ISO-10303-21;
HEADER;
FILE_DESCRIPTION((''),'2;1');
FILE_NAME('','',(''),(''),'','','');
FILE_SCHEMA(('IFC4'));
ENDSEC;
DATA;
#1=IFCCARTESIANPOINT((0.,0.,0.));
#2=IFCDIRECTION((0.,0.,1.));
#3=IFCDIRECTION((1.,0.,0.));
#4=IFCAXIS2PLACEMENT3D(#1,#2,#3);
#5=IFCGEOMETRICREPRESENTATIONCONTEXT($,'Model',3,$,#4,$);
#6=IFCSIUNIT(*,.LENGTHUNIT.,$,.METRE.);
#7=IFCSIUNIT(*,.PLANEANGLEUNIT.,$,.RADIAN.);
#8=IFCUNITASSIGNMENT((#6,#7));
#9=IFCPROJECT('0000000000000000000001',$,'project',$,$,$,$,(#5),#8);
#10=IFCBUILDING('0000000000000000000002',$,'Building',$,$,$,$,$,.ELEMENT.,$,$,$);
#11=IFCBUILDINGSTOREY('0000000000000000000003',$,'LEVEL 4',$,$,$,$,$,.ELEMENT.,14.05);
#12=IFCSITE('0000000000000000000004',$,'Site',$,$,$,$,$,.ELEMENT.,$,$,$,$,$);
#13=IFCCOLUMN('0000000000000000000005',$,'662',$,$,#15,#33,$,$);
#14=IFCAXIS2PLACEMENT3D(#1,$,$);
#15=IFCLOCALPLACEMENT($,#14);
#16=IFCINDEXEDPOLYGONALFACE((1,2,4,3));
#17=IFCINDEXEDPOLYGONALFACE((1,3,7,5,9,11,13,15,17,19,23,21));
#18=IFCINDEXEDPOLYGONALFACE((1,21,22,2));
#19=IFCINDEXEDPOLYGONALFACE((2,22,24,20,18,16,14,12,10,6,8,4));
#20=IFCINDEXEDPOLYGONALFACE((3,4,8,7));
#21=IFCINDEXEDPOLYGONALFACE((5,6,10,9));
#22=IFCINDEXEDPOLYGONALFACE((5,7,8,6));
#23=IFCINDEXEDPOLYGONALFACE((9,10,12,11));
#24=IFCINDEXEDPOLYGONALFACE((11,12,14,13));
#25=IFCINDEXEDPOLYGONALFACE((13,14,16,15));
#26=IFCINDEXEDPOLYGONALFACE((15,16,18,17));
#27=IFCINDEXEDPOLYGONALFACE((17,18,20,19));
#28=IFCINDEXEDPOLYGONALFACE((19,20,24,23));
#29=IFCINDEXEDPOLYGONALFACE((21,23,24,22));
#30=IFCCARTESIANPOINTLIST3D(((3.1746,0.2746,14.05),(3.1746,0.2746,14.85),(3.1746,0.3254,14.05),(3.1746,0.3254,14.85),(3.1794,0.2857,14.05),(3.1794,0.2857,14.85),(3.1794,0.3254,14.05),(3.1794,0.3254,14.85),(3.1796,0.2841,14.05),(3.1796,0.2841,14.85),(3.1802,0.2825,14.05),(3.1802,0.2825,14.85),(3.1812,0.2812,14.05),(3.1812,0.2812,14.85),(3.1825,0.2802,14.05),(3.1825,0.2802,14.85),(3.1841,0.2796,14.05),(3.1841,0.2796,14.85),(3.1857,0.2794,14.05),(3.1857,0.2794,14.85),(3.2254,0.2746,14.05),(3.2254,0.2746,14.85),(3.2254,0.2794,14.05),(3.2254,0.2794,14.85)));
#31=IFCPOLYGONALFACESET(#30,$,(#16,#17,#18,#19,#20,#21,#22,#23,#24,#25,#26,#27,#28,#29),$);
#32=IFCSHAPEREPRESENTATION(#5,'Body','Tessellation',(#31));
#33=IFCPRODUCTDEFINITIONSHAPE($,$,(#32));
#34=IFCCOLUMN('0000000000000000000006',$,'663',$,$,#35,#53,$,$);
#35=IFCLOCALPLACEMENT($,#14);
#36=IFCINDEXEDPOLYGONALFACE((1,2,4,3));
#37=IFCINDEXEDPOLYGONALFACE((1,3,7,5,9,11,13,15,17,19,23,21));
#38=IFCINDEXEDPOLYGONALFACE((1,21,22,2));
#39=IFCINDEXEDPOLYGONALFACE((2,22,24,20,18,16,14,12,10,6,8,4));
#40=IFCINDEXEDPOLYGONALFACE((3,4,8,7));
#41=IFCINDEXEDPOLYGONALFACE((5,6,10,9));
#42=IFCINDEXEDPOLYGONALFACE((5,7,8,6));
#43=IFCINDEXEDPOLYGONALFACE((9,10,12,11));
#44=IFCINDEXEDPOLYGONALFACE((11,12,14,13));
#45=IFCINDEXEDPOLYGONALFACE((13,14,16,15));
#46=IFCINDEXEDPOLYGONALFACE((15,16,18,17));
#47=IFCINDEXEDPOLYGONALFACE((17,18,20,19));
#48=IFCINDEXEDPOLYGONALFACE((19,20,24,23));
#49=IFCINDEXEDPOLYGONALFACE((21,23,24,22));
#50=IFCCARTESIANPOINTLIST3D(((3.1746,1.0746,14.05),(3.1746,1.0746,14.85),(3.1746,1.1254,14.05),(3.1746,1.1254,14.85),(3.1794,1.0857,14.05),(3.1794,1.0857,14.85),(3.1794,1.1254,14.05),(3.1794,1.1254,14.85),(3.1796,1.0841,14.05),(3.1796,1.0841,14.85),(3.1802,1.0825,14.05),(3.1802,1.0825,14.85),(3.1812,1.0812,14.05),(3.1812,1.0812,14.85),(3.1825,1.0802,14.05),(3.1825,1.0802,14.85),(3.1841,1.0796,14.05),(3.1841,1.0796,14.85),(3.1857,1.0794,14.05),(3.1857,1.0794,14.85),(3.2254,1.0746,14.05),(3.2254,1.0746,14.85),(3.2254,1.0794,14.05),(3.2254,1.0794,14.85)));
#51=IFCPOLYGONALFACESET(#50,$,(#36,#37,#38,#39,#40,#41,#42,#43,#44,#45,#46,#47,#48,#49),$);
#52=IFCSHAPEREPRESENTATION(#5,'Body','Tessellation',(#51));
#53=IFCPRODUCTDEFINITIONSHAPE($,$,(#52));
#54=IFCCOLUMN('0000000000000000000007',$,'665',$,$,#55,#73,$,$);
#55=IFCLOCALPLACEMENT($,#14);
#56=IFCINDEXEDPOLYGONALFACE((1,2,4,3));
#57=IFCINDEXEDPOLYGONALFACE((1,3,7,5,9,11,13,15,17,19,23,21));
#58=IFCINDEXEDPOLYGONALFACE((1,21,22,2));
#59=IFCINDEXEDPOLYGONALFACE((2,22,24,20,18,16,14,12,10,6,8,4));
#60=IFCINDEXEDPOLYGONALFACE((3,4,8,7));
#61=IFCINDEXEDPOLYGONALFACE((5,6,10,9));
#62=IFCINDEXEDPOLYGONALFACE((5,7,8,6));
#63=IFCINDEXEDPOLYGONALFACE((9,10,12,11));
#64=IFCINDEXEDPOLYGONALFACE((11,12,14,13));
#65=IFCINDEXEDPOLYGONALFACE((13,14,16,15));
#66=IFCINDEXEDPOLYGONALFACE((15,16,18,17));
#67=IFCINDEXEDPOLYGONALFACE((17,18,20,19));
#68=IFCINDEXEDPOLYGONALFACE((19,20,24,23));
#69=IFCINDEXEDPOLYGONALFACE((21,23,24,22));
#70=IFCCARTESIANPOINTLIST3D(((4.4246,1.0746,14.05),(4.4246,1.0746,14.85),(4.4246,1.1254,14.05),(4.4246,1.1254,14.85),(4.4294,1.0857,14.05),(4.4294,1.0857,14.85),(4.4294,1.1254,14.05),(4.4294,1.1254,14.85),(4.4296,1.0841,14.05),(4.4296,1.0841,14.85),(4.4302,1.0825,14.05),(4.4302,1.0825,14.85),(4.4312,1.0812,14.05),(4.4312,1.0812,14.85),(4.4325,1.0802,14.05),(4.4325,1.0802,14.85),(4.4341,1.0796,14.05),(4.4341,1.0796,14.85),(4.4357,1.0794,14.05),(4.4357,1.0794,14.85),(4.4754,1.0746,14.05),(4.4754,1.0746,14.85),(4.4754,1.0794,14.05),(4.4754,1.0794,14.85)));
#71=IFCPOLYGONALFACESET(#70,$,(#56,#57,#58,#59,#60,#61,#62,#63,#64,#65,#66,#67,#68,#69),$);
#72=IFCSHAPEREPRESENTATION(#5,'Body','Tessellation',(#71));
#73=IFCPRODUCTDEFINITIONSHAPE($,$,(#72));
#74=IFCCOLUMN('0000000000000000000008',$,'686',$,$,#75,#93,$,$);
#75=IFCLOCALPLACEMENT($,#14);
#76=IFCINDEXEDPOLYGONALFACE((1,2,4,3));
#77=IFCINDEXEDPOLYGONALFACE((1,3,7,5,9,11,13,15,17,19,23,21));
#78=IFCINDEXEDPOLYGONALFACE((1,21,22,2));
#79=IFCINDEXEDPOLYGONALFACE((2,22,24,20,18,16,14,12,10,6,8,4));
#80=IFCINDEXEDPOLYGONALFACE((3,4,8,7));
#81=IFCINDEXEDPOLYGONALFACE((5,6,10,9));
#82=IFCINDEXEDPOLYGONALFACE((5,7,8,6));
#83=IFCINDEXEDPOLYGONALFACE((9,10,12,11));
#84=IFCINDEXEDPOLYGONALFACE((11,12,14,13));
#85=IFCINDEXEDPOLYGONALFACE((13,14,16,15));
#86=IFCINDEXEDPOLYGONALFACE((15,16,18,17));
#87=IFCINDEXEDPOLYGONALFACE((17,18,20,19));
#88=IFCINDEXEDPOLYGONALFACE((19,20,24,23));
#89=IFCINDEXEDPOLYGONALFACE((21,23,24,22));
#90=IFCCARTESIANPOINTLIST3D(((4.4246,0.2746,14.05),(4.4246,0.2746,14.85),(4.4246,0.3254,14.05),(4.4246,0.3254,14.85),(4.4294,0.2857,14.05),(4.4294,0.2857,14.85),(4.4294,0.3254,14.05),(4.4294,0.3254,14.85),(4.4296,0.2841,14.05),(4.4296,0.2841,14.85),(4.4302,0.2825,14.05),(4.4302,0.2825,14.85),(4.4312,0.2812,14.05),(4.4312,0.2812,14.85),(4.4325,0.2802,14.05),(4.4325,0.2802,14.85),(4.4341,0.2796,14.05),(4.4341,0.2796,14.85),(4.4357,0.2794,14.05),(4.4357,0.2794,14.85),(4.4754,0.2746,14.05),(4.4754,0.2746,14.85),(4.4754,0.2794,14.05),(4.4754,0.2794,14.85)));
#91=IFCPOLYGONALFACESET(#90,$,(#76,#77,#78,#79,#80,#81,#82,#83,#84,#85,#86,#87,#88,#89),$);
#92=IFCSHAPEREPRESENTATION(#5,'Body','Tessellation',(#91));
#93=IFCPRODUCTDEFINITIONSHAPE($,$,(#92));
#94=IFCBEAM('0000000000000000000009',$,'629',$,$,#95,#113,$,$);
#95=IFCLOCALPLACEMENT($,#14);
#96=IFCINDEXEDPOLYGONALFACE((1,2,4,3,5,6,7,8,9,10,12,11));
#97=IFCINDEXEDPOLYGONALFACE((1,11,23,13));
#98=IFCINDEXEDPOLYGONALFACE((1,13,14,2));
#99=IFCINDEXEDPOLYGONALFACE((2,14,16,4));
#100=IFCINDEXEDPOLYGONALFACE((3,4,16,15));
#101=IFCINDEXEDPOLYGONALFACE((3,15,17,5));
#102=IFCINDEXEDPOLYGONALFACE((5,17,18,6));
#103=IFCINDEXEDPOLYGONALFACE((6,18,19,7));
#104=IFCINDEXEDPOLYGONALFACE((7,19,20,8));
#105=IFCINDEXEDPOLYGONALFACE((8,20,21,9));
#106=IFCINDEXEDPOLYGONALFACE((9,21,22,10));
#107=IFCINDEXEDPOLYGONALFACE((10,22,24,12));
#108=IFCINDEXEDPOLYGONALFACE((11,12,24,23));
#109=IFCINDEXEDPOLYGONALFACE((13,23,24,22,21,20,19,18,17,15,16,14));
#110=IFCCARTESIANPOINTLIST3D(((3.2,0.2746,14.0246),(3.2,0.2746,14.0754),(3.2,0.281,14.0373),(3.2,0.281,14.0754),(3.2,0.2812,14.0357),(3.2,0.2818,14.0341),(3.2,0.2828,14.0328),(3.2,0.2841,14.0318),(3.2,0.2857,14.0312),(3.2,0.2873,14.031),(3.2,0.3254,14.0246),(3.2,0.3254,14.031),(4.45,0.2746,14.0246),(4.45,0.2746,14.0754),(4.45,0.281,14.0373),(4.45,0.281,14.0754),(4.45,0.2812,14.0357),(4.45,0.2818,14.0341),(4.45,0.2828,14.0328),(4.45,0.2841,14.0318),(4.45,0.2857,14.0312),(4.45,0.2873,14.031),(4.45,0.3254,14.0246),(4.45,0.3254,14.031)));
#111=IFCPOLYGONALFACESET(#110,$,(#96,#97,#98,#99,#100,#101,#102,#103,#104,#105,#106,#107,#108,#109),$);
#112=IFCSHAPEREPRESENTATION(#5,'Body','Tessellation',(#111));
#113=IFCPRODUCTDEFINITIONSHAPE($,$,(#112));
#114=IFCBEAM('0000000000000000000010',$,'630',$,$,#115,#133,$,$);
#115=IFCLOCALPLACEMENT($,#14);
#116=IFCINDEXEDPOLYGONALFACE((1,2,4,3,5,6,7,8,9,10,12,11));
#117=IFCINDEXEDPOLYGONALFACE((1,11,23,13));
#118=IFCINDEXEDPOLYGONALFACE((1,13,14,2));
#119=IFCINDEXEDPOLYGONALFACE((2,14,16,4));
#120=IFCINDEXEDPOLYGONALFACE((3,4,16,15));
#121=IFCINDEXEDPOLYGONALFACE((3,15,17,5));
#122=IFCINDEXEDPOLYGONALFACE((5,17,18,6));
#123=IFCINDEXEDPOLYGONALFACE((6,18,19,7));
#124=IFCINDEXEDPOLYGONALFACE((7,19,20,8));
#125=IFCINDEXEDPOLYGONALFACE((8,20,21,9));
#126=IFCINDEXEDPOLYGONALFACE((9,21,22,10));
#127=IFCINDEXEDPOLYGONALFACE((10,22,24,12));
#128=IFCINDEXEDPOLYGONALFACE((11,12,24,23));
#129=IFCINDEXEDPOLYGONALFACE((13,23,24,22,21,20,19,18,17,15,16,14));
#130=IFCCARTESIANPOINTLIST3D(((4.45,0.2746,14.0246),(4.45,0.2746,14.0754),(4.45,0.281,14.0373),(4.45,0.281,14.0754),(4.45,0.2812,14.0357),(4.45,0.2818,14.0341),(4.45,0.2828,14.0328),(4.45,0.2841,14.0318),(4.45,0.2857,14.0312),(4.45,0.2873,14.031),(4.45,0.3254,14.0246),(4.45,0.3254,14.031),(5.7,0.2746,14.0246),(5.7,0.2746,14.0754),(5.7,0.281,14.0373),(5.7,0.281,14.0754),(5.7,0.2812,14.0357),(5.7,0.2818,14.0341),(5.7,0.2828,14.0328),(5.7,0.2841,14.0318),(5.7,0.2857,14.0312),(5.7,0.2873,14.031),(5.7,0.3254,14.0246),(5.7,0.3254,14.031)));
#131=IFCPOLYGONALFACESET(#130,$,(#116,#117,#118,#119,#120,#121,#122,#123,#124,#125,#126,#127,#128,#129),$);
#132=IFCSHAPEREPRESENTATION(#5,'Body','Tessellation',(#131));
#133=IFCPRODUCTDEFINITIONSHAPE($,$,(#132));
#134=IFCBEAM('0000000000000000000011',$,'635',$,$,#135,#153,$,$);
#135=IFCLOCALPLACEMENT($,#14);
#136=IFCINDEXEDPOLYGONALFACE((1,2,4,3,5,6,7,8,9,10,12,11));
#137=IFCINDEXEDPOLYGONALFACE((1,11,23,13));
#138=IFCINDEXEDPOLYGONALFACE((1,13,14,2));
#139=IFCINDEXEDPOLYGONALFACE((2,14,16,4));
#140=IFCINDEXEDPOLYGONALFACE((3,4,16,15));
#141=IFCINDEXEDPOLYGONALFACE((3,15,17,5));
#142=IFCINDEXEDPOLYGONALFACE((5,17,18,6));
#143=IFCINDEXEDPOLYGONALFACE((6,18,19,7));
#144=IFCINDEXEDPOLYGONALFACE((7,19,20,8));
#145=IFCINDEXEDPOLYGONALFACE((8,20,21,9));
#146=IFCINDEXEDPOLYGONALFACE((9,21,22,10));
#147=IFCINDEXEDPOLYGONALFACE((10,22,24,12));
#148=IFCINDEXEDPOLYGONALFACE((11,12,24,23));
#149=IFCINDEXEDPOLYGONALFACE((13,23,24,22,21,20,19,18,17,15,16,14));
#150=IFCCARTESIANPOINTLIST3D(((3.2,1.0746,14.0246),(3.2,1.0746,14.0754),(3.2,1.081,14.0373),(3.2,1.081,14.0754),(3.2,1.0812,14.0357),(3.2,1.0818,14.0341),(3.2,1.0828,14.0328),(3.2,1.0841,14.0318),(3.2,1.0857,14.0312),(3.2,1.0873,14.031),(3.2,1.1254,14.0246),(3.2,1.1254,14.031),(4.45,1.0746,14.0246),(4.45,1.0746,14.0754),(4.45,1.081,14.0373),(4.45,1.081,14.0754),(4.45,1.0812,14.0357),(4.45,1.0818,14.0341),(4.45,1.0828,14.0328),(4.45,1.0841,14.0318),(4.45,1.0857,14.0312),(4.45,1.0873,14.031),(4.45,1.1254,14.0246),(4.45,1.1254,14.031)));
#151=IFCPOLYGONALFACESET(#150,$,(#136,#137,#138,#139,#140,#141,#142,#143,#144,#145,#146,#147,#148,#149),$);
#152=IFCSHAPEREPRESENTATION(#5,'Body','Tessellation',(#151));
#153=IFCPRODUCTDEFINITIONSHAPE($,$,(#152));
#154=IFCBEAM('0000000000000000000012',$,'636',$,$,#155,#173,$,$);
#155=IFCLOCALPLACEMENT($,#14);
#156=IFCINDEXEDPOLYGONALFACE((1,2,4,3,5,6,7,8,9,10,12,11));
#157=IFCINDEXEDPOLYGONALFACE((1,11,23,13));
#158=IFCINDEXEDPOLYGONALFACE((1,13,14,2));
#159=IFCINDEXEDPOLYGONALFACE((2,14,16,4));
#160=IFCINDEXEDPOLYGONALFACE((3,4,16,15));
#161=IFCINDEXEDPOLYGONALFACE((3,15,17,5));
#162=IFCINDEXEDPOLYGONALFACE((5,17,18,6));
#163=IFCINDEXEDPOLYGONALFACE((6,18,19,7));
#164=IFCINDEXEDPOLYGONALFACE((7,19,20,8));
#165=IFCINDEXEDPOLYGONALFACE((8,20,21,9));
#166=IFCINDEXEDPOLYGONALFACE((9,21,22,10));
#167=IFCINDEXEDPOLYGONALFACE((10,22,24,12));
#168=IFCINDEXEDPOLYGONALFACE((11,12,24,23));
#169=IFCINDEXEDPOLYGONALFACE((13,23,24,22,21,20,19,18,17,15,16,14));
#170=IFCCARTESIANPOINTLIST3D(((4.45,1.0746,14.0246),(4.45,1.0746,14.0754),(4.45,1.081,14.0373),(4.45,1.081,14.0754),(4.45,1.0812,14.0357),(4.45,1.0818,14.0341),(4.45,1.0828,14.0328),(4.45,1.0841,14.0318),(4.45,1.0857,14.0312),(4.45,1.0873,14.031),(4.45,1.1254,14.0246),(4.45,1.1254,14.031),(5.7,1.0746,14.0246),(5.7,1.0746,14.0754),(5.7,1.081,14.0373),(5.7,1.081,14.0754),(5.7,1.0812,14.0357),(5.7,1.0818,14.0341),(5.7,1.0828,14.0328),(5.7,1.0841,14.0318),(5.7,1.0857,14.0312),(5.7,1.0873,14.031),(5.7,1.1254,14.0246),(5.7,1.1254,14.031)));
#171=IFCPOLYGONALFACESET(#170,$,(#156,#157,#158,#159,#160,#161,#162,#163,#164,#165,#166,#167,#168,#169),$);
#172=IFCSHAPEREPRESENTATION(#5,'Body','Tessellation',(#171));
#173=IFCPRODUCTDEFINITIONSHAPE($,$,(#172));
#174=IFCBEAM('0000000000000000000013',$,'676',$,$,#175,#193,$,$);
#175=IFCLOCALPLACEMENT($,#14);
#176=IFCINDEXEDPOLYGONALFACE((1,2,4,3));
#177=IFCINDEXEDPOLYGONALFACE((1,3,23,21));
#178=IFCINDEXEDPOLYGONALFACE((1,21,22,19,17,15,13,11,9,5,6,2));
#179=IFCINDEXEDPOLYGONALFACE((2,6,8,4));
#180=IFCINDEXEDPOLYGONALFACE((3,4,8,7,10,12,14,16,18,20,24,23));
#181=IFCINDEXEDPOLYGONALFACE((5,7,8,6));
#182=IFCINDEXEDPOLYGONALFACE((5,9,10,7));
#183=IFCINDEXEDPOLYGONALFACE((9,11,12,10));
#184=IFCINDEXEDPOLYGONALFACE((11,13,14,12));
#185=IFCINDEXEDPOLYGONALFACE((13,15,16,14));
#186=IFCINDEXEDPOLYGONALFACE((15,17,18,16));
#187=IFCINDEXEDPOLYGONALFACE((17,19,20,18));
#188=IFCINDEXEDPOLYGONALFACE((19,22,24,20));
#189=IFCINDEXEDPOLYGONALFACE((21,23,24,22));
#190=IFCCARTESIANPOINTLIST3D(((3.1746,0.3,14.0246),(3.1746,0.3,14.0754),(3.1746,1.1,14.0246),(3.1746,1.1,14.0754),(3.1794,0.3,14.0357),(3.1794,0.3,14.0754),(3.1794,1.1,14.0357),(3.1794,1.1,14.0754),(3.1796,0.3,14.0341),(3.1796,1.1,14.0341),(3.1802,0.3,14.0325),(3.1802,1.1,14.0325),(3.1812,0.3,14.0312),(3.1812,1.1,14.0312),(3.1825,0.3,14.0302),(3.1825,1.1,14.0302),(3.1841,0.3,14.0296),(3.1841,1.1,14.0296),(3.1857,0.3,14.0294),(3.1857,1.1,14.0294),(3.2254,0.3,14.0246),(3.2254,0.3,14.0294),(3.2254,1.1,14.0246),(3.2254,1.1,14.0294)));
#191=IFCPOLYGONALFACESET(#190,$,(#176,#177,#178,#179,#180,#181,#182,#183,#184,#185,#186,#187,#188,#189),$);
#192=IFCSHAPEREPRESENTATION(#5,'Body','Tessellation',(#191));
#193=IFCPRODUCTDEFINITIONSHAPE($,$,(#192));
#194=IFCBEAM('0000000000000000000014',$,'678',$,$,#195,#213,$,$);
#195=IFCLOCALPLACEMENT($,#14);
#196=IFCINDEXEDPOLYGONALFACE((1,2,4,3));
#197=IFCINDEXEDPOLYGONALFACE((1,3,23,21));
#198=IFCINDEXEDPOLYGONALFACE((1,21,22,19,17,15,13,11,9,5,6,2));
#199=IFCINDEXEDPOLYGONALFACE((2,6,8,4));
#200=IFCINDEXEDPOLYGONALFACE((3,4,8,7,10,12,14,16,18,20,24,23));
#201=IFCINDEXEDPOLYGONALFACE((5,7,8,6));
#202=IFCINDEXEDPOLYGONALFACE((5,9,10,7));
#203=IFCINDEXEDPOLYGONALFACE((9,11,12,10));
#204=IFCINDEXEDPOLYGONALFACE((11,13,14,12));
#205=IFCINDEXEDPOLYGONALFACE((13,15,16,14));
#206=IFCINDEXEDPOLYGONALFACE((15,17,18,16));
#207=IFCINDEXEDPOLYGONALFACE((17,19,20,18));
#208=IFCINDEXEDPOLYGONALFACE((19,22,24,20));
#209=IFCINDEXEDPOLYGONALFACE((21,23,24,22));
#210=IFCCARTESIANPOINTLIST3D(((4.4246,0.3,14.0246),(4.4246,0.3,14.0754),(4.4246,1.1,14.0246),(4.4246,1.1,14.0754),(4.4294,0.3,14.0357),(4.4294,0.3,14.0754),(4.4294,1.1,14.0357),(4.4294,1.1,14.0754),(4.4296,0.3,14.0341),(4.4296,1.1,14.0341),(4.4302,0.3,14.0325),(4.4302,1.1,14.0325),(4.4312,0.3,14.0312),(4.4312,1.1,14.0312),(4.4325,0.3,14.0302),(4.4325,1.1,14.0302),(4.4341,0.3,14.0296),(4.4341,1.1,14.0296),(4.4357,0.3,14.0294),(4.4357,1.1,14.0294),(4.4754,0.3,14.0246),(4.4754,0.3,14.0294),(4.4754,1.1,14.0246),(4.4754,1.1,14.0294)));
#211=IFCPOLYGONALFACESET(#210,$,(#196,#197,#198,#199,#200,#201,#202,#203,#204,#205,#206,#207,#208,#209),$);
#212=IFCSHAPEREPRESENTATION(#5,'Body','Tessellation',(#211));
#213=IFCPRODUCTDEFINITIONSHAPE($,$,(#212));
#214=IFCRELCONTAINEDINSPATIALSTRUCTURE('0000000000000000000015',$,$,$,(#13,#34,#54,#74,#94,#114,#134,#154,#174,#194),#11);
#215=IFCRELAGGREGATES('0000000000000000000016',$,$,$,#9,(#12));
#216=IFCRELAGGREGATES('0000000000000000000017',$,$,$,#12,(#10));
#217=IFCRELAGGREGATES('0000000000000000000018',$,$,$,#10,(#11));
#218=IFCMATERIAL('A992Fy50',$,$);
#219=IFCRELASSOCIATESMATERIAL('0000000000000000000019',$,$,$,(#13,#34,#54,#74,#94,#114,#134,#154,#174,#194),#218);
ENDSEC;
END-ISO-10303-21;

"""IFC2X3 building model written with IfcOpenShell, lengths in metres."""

from ifc_helpers import new_model, si_unit, frame, origin_with_axes, origin_2d_with_axis, place, context, project, spatial, l_section, extrude, material, element, save


model = new_model("IFC2X3")

# Units and contexts
model_context = context("Model", 3, world=origin_with_axes())
ifc_project = project(units=[si_unit("LENGTHUNIT", "METRE"), si_unit("PLANEANGLEUNIT", "RADIAN")], contexts=[model_context])

# Site, building, storey
site = spatial("IfcSite", under=ifc_project, Name="Site", CompositionType="ELEMENT")
building = spatial("IfcBuilding", under=site, Name="Building", CompositionType="ELEMENT")
storey = spatial("IfcBuildingStorey", under=building, Name="LEVEL 4", CompositionType="ELEMENT", Elevation=14.05)

# Columns
ifc_material = material(Name="A992Fy50")
for number, where, z_axis, x_axis, name in (
    (1, (3.2, 0.3, 14.85), (0.0, 0.0, -1.0), (0.0, 1.0, 0.0), "662"),
    (2, (3.2, 1.1, 14.85), (0.0, 0.0, -1.0), (0.0, 1.0, 0.0), "663"),
    (3, (4.45, 1.1, 14.85), (0.0, 0.0, -1.0), (0.0, 1.0, 0.0), "665"),
    (4, (4.45, 0.3, 14.85), (0.0, 0.0, -1.0), (0.0, 1.0, 0.0), "686"),
):
    element("IfcColumn", number, at=place(None, frame(where, z_axis=z_axis, x_axis=x_axis)), inside=storey, material=ifc_material, Name=name, context=model_context, shape_type="SweptSolid", body=[
        extrude(l_section(Depth=0.0508, Width=0.0508, Thickness=0.0048, FilletRadius=0.0063, at=origin_2d_with_axis()), origin_with_axes(), (0.0, 0.0, 1.0), 0.8),
    ])

# Beams
for number, where, z_axis, x_axis, name in (
    (5, (3.2, 0.3, 14.05), (1.0, 0.0, 0.0), (0.0, 1.0, 0.0), "629"),
    (6, (4.45, 0.3, 14.05), (1.0, 0.0, 0.0), (0.0, 1.0, 0.0), "630"),
    (7, (3.2, 1.1, 14.05), (1.0, 0.0, 0.0), (0.0, 1.0, 0.0), "635"),
    (8, (4.45, 1.1, 14.05), (1.0, 0.0, 0.0), (0.0, 1.0, 0.0), "636"),
):
    element("IfcBeam", number, at=place(None, frame(where, z_axis=z_axis, x_axis=x_axis)), inside=storey, material=ifc_material, Name=name, context=model_context, shape_type="SweptSolid", body=[
        extrude(l_section(Depth=0.0508, Width=0.0508, Thickness=0.0063, FilletRadius=0.0063, at=origin_2d_with_axis()), origin_with_axes(), (0.0, 0.0, 1.0), 1.25),
    ])
for number, where, z_axis, x_axis, name in (
    (9, (3.2, 1.1, 14.05), (0.0, -1.0, 0.0), (1.0, 0.0, 0.0), "676"),
    (10, (4.45, 1.1, 14.05), (0.0, -1.0, 0.0), (1.0, 0.0, 0.0), "678"),
):
    element("IfcBeam", number, at=place(None, frame(where, z_axis=z_axis, x_axis=x_axis)), inside=storey, material=ifc_material, Name=name, context=model_context, shape_type="SweptSolid", body=[
        extrude(l_section(Depth=0.0508, Width=0.0508, Thickness=0.0048, FilletRadius=0.0063, at=origin_2d_with_axis()), origin_with_axes(), (0.0, 0.0, 1.0), 0.8),
    ])

save(model, "model.ifc")
